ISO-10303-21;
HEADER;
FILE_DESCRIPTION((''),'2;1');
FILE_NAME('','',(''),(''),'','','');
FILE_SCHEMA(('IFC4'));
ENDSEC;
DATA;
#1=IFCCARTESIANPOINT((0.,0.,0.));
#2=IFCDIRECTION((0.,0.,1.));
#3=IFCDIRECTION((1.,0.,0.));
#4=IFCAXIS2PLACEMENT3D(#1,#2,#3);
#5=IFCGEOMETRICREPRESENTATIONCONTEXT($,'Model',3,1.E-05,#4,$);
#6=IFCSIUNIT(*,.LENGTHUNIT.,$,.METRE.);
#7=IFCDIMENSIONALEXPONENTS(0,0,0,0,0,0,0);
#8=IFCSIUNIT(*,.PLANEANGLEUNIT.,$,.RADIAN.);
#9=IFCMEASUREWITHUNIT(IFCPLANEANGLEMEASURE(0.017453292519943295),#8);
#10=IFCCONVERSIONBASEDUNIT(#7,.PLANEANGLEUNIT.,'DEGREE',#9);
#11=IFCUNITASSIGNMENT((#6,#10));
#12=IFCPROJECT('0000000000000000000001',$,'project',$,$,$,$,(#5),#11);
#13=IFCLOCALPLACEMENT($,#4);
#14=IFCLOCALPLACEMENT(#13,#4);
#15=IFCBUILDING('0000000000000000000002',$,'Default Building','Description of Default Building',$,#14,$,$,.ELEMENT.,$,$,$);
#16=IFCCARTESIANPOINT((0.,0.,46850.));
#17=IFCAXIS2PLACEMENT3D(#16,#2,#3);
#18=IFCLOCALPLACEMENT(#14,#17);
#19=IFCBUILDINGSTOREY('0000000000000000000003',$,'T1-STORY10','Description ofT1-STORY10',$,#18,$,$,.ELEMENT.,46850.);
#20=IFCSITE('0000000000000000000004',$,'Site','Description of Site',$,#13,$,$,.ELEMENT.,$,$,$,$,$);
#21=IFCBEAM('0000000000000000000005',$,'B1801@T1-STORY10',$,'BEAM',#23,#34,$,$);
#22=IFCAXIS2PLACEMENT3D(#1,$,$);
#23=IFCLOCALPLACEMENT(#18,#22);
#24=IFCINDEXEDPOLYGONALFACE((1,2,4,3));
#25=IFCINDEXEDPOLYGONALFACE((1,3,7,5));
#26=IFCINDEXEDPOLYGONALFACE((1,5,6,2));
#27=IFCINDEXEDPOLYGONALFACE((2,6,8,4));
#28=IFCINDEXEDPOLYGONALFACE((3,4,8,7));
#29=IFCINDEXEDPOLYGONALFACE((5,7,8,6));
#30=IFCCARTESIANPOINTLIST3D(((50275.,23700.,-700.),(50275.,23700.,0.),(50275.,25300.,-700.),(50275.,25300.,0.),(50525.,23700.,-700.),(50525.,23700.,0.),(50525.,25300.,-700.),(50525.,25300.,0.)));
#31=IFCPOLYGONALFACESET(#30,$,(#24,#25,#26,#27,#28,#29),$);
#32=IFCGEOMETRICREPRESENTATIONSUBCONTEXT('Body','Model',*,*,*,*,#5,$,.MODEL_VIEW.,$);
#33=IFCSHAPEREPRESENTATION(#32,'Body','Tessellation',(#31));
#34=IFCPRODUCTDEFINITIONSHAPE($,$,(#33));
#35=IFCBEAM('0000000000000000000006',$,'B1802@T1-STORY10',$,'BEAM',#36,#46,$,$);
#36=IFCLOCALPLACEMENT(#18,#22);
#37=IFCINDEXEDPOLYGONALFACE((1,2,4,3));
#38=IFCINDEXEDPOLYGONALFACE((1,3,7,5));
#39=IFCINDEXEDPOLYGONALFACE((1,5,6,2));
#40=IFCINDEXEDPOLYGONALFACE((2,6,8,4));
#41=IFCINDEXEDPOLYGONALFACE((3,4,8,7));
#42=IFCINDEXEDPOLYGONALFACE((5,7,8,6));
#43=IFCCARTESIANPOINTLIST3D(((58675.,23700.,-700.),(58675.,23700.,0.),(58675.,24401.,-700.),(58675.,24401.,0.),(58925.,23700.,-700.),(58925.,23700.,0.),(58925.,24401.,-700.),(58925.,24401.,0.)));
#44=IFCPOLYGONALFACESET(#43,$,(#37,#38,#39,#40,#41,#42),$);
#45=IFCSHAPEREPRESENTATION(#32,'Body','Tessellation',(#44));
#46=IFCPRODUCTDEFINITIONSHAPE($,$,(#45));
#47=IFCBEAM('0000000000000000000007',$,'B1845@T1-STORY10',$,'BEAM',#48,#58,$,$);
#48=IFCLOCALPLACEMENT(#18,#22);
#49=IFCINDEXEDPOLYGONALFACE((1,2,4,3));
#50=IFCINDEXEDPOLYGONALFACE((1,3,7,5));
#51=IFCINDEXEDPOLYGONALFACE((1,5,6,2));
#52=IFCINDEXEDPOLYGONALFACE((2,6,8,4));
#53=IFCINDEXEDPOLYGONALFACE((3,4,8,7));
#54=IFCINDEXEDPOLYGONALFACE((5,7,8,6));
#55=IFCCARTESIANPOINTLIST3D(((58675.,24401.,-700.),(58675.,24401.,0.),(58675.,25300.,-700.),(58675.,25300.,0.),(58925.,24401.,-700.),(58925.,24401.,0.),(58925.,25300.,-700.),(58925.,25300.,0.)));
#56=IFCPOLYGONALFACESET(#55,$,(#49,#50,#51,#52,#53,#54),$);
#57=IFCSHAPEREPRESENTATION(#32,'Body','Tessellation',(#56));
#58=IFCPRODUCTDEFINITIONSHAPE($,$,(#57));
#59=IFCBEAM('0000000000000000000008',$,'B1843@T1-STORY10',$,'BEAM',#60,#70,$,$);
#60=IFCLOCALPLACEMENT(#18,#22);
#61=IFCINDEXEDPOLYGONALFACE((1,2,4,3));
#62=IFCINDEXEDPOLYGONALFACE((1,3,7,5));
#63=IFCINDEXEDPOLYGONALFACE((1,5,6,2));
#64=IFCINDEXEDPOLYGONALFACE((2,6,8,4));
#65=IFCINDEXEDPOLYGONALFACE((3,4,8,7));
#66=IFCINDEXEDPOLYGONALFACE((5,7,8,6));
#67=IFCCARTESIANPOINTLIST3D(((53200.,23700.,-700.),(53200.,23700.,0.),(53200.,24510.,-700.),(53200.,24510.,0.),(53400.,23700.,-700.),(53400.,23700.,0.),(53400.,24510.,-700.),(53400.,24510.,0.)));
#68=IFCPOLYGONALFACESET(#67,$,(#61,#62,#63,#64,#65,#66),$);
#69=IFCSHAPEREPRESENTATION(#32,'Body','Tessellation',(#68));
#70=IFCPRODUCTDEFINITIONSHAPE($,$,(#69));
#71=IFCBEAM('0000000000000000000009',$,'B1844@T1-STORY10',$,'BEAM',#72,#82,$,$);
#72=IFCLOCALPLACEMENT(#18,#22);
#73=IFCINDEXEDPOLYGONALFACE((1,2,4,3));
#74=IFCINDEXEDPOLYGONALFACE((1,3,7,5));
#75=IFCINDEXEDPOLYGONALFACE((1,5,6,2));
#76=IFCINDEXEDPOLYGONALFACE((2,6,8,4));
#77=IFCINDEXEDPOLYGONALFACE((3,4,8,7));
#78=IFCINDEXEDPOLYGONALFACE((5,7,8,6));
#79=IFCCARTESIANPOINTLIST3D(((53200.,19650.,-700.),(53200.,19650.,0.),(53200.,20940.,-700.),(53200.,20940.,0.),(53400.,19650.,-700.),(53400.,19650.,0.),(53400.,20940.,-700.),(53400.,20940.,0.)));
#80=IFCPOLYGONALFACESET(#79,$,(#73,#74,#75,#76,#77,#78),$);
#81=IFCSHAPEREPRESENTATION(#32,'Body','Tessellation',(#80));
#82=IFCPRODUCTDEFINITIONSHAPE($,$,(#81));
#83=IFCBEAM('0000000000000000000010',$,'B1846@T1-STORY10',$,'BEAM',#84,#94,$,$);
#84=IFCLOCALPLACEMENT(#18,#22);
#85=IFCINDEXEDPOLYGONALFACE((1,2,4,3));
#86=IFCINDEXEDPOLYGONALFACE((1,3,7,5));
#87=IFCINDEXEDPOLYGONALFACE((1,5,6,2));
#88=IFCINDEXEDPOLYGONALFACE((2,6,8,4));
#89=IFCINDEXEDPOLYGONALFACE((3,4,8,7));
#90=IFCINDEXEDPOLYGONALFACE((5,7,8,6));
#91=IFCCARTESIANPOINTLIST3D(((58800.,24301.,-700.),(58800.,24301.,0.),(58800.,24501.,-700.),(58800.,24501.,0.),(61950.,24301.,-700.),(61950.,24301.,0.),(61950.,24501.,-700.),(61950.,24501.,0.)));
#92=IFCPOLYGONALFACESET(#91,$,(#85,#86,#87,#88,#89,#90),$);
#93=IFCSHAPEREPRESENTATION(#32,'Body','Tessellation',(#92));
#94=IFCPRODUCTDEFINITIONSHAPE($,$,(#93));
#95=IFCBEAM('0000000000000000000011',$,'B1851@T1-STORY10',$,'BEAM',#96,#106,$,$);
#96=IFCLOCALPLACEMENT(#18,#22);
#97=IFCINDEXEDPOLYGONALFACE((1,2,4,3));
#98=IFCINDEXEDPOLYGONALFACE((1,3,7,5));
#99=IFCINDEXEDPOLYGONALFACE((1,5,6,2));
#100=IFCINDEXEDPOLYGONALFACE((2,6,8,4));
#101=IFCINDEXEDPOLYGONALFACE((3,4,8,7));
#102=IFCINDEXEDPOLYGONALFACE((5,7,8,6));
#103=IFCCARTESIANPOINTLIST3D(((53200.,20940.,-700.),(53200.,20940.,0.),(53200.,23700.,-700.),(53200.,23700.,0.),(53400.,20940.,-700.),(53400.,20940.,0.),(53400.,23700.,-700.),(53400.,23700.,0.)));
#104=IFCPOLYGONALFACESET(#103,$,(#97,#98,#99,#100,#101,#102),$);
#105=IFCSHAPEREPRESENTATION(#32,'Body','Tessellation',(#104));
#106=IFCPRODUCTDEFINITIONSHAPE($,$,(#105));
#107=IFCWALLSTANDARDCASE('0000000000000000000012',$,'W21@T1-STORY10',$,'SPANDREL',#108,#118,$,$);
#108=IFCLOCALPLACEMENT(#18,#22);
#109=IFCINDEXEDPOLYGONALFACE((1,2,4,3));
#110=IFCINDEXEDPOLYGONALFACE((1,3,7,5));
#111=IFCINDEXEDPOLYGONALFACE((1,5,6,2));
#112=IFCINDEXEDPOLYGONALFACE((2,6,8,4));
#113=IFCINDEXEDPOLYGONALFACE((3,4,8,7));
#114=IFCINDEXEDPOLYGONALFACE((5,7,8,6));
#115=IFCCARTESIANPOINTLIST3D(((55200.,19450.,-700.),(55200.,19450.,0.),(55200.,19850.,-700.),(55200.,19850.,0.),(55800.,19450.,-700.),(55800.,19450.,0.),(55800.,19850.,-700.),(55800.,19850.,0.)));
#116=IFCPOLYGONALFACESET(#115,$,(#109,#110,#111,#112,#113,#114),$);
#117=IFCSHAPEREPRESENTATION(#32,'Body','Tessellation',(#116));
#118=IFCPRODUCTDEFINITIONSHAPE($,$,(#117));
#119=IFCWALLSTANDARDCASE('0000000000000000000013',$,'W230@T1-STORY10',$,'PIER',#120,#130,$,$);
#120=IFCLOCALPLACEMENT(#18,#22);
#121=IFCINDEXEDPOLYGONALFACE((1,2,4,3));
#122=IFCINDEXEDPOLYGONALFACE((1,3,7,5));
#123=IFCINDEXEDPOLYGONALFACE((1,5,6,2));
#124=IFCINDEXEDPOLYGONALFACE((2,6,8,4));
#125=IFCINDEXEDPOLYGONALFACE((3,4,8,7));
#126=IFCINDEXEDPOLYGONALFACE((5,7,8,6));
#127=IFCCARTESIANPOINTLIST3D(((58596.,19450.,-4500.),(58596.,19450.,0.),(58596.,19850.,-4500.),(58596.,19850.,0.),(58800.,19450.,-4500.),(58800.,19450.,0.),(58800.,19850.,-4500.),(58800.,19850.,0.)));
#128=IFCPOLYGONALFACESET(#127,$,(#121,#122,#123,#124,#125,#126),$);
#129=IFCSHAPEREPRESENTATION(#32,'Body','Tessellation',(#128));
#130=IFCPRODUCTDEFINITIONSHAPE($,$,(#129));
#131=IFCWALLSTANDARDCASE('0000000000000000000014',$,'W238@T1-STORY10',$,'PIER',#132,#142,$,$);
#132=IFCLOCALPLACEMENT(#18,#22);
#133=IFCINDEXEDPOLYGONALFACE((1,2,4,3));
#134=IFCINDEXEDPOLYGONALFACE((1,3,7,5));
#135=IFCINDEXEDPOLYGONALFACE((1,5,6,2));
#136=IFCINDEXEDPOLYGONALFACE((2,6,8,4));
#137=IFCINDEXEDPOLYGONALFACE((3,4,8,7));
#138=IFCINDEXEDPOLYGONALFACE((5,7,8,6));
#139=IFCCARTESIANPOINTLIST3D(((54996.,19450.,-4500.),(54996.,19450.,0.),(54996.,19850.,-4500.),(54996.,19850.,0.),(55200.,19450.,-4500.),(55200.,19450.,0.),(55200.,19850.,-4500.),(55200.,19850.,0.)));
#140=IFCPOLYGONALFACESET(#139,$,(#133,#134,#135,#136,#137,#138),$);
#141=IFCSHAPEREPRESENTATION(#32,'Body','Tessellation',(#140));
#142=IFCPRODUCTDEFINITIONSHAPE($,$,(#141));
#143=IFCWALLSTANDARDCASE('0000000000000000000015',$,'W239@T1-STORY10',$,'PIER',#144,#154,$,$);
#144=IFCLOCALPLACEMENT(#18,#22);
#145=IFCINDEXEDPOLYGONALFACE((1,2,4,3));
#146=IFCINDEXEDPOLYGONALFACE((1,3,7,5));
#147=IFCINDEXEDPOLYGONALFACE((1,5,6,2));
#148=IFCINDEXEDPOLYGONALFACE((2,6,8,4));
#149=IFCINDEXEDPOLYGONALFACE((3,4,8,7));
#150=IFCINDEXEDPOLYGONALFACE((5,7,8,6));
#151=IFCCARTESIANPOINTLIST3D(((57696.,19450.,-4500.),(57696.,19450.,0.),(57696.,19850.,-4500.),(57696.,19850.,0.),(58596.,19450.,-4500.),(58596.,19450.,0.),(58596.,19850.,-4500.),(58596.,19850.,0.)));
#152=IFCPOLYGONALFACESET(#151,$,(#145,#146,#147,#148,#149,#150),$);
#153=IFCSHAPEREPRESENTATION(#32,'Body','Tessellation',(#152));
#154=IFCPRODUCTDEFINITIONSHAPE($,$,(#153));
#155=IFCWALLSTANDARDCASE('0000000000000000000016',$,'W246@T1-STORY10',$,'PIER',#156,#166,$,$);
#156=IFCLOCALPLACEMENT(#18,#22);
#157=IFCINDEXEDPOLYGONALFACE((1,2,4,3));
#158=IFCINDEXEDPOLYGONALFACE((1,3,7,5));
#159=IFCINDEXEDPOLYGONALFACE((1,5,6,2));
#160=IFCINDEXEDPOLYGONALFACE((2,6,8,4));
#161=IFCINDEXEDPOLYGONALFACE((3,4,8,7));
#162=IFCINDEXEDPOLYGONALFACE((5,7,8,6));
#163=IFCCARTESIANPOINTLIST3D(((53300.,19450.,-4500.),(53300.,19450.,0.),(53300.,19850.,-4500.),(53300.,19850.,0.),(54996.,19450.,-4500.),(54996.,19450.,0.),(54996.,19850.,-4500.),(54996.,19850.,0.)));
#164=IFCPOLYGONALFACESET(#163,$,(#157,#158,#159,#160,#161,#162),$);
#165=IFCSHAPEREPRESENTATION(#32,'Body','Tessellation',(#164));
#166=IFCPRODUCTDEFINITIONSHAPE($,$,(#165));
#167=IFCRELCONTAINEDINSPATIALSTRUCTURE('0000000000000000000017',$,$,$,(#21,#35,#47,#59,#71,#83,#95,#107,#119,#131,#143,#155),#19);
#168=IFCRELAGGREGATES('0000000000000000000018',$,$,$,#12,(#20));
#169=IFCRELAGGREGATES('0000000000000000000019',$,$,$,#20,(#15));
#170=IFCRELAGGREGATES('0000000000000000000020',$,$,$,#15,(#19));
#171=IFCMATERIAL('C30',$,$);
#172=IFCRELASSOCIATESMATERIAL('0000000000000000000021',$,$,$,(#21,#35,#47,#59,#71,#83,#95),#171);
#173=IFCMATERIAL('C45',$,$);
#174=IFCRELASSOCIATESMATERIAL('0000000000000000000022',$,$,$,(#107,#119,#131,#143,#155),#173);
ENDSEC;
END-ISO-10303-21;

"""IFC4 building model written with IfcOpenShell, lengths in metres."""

from ifc_helpers import new_model, entity, si_unit, converted_unit, frame, origin_with_axes, place, context, subcontext, project, spatial, indexed_curve, rectangle, outline, extrude, material, element, save


model = new_model("IFC4")

# Units and contexts
model_context = context("Model", 3, precision=1e-05, world=origin_with_axes())
body_context = subcontext(model_context, "Body", "Model", "MODEL_VIEW")
ifc_project = project(units=[si_unit("LENGTHUNIT", "METRE"), converted_unit("PLANEANGLEUNIT", "DEGREE", entity("IfcPlaneAngleMeasure", 0.017453292519943295), si_unit("PLANEANGLEUNIT", "RADIAN"), dimensions=[0, 0, 0, 0, 0, 0, 0])], contexts=[model_context])

# Site, building, storey
site_placement = place(None, origin_with_axes())
site = spatial("IfcSite", under=ifc_project, at=site_placement, Name="Site", Description="Description of Site", CompositionType="ELEMENT")
building_placement = place(site_placement, origin_with_axes())
building = spatial("IfcBuilding", under=site, at=building_placement, Name="Default Building", Description="Description of Default Building", CompositionType="ELEMENT")
storey_placement = place(building_placement, frame((0.0, 0.0, 46850.0), z_axis=(0.0, 0.0, 1.0), x_axis=(1.0, 0.0, 0.0)))
storey = spatial("IfcBuildingStorey", under=building, at=storey_placement, Name="T1-STORY10", Description="Description ofT1-STORY10", CompositionType="ELEMENT", Elevation=46850.0)

# Beams
ifc_material_1 = material(Name="C30")
beam_1_placement = place(storey_placement, frame((50400.0, 23700.0, -350.0), z_axis=(0.0, 1.0, 0.0), x_axis=(-1.0, 0.0, 0.0)))
element("IfcBeam", 1, at=beam_1_placement, inside=storey, material=ifc_material_1, Name="B1801@T1-STORY10", ObjectType="BEAM", context=body_context, shape_type="SweptSolid", body=[
    extrude(rectangle(XDim=250.0, YDim=700.0), origin_with_axes(), (0.0, 0.0, 1.0), 1600.0),
])
beam_2_placement = place(storey_placement, frame((58800.0, 23700.0, -350.0), z_axis=(0.0, 1.0, 0.0), x_axis=(-1.0, 0.0, 0.0)))
element("IfcBeam", 2, at=beam_2_placement, inside=storey, material=ifc_material_1, Name="B1802@T1-STORY10", ObjectType="BEAM", context=body_context, shape_type="SweptSolid", body=[
    extrude(rectangle(XDim=250.0, YDim=700.0), origin_with_axes(), (0.0, 0.0, 1.0), 701.0),
])
beam_3_placement = place(storey_placement, frame((58800.0, 24401.0, -350.0), z_axis=(0.0, 1.0, 0.0), x_axis=(-1.0, 0.0, 0.0)))
element("IfcBeam", 3, at=beam_3_placement, inside=storey, material=ifc_material_1, Name="B1845@T1-STORY10", ObjectType="BEAM", context=body_context, shape_type="SweptSolid", body=[
    extrude(rectangle(XDim=250.0, YDim=700.0), origin_with_axes(), (0.0, 0.0, 1.0), 899.0),
])
beam_4_placement = place(storey_placement, frame((53300.0, 23700.0, -350.0), z_axis=(0.0, 1.0, 0.0), x_axis=(-1.0, 0.0, 0.0)))
element("IfcBeam", 4, at=beam_4_placement, inside=storey, material=ifc_material_1, Name="B1843@T1-STORY10", ObjectType="BEAM", context=body_context, shape_type="SweptSolid", body=[
    extrude(rectangle(XDim=200.0, YDim=700.0), origin_with_axes(), (0.0, 0.0, 1.0), 810.0),
])
beam_5_placement = place(storey_placement, frame((53300.0, 19650.0, -350.0), z_axis=(0.0, 1.0, 0.0), x_axis=(-1.0, 0.0, 0.0)))
element("IfcBeam", 5, at=beam_5_placement, inside=storey, material=ifc_material_1, Name="B1844@T1-STORY10", ObjectType="BEAM", context=body_context, shape_type="SweptSolid", body=[
    extrude(rectangle(XDim=200.0, YDim=700.0), origin_with_axes(), (0.0, 0.0, 1.0), 1290.0),
])
beam_6_placement = place(storey_placement, frame((58800.0, 24401.0, -350.0), z_axis=(1.0, 0.0, 0.0), x_axis=(0.0, 1.0, 0.0)))
element("IfcBeam", 6, at=beam_6_placement, inside=storey, material=ifc_material_1, Name="B1846@T1-STORY10", ObjectType="BEAM", context=body_context, shape_type="SweptSolid", body=[
    extrude(rectangle(XDim=200.0, YDim=700.0), origin_with_axes(), (0.0, 0.0, 1.0), 3150.0),
])
beam_7_placement = place(storey_placement, frame((53300.0, 20940.0, -350.0), z_axis=(0.0, 1.0, 0.0), x_axis=(-1.0, 0.0, 0.0)))
element("IfcBeam", 7, at=beam_7_placement, inside=storey, material=ifc_material_1, Name="B1851@T1-STORY10", ObjectType="BEAM", context=body_context, shape_type="SweptSolid", body=[
    extrude(rectangle(XDim=200.0, YDim=700.0), origin_with_axes(), (0.0, 0.0, 1.0), 2760.0),
])
ifc_material_2 = material(Name="C45")

# Walls
wall_1_placement = place(storey_placement, frame((55200.0, 19650.0, -700.0), z_axis=(0.0, 0.0, 1.0), x_axis=(1.0, 0.0, 0.0)))
element("IfcWallStandardCase", 8, at=wall_1_placement, inside=storey, material=ifc_material_2, Name="W21@T1-STORY10", ObjectType="SPANDREL", context=body_context, shape_type="SweptSolid", body=[
    extrude(outline(indexed_curve([(0.0, -200.0), (0.0, 200.0), (600.0, 200.0), (600.0, -200.0), (0.0, -200.0)], self_intersect=False)), origin_with_axes(), (0.0, 0.0, 1.0), 700.0),
])
for number, where, z_axis, x_axis, name in (
    (9, (58596.0, 19650.0, -4500.0), (0.0, 0.0, 1.0), (1.0, 0.0, 0.0), "W230@T1-STORY10"),
    (10, (54996.0, 19650.0, -4500.0), (0.0, 0.0, 1.0), (1.0, 0.0, 0.0), "W238@T1-STORY10"),
):
    element("IfcWallStandardCase", number, at=place(storey_placement, frame(where, z_axis=z_axis, x_axis=x_axis)), inside=storey, material=ifc_material_2, Name=name, ObjectType="PIER", context=body_context, shape_type="SweptSolid", body=[
        extrude(outline(indexed_curve([(0.0, -200.0), (0.0, 200.0), (204.0, 200.0), (204.0, -200.0), (0.0, -200.0)], self_intersect=False)), origin_with_axes(), (0.0, 0.0, 1.0), 4500.0),
    ])
wall_2_placement = place(storey_placement, frame((57696.0, 19650.0, -4500.0), z_axis=(0.0, 0.0, 1.0), x_axis=(1.0, 0.0, 0.0)))
element("IfcWallStandardCase", 11, at=wall_2_placement, inside=storey, material=ifc_material_2, Name="W239@T1-STORY10", ObjectType="PIER", context=body_context, shape_type="SweptSolid", body=[
    extrude(outline(indexed_curve([(0.0, -200.0), (0.0, 200.0), (900.0, 200.0), (900.0, -200.0), (0.0, -200.0)], self_intersect=False)), origin_with_axes(), (0.0, 0.0, 1.0), 4500.0),
])
wall_3_placement = place(storey_placement, frame((53300.0, 19650.0, -4500.0), z_axis=(0.0, 0.0, 1.0), x_axis=(1.0, 0.0, 0.0)))
element("IfcWallStandardCase", 12, at=wall_3_placement, inside=storey, material=ifc_material_2, Name="W246@T1-STORY10", ObjectType="PIER", context=body_context, shape_type="SweptSolid", body=[
    extrude(outline(indexed_curve([(0.0, -200.0), (0.0, 200.0), (1696.0, 200.0), (1696.0, -200.0), (0.0, -200.0)], self_intersect=False)), origin_with_axes(), (0.0, 0.0, 1.0), 4500.0),
])

save(model, "model.ifc")
